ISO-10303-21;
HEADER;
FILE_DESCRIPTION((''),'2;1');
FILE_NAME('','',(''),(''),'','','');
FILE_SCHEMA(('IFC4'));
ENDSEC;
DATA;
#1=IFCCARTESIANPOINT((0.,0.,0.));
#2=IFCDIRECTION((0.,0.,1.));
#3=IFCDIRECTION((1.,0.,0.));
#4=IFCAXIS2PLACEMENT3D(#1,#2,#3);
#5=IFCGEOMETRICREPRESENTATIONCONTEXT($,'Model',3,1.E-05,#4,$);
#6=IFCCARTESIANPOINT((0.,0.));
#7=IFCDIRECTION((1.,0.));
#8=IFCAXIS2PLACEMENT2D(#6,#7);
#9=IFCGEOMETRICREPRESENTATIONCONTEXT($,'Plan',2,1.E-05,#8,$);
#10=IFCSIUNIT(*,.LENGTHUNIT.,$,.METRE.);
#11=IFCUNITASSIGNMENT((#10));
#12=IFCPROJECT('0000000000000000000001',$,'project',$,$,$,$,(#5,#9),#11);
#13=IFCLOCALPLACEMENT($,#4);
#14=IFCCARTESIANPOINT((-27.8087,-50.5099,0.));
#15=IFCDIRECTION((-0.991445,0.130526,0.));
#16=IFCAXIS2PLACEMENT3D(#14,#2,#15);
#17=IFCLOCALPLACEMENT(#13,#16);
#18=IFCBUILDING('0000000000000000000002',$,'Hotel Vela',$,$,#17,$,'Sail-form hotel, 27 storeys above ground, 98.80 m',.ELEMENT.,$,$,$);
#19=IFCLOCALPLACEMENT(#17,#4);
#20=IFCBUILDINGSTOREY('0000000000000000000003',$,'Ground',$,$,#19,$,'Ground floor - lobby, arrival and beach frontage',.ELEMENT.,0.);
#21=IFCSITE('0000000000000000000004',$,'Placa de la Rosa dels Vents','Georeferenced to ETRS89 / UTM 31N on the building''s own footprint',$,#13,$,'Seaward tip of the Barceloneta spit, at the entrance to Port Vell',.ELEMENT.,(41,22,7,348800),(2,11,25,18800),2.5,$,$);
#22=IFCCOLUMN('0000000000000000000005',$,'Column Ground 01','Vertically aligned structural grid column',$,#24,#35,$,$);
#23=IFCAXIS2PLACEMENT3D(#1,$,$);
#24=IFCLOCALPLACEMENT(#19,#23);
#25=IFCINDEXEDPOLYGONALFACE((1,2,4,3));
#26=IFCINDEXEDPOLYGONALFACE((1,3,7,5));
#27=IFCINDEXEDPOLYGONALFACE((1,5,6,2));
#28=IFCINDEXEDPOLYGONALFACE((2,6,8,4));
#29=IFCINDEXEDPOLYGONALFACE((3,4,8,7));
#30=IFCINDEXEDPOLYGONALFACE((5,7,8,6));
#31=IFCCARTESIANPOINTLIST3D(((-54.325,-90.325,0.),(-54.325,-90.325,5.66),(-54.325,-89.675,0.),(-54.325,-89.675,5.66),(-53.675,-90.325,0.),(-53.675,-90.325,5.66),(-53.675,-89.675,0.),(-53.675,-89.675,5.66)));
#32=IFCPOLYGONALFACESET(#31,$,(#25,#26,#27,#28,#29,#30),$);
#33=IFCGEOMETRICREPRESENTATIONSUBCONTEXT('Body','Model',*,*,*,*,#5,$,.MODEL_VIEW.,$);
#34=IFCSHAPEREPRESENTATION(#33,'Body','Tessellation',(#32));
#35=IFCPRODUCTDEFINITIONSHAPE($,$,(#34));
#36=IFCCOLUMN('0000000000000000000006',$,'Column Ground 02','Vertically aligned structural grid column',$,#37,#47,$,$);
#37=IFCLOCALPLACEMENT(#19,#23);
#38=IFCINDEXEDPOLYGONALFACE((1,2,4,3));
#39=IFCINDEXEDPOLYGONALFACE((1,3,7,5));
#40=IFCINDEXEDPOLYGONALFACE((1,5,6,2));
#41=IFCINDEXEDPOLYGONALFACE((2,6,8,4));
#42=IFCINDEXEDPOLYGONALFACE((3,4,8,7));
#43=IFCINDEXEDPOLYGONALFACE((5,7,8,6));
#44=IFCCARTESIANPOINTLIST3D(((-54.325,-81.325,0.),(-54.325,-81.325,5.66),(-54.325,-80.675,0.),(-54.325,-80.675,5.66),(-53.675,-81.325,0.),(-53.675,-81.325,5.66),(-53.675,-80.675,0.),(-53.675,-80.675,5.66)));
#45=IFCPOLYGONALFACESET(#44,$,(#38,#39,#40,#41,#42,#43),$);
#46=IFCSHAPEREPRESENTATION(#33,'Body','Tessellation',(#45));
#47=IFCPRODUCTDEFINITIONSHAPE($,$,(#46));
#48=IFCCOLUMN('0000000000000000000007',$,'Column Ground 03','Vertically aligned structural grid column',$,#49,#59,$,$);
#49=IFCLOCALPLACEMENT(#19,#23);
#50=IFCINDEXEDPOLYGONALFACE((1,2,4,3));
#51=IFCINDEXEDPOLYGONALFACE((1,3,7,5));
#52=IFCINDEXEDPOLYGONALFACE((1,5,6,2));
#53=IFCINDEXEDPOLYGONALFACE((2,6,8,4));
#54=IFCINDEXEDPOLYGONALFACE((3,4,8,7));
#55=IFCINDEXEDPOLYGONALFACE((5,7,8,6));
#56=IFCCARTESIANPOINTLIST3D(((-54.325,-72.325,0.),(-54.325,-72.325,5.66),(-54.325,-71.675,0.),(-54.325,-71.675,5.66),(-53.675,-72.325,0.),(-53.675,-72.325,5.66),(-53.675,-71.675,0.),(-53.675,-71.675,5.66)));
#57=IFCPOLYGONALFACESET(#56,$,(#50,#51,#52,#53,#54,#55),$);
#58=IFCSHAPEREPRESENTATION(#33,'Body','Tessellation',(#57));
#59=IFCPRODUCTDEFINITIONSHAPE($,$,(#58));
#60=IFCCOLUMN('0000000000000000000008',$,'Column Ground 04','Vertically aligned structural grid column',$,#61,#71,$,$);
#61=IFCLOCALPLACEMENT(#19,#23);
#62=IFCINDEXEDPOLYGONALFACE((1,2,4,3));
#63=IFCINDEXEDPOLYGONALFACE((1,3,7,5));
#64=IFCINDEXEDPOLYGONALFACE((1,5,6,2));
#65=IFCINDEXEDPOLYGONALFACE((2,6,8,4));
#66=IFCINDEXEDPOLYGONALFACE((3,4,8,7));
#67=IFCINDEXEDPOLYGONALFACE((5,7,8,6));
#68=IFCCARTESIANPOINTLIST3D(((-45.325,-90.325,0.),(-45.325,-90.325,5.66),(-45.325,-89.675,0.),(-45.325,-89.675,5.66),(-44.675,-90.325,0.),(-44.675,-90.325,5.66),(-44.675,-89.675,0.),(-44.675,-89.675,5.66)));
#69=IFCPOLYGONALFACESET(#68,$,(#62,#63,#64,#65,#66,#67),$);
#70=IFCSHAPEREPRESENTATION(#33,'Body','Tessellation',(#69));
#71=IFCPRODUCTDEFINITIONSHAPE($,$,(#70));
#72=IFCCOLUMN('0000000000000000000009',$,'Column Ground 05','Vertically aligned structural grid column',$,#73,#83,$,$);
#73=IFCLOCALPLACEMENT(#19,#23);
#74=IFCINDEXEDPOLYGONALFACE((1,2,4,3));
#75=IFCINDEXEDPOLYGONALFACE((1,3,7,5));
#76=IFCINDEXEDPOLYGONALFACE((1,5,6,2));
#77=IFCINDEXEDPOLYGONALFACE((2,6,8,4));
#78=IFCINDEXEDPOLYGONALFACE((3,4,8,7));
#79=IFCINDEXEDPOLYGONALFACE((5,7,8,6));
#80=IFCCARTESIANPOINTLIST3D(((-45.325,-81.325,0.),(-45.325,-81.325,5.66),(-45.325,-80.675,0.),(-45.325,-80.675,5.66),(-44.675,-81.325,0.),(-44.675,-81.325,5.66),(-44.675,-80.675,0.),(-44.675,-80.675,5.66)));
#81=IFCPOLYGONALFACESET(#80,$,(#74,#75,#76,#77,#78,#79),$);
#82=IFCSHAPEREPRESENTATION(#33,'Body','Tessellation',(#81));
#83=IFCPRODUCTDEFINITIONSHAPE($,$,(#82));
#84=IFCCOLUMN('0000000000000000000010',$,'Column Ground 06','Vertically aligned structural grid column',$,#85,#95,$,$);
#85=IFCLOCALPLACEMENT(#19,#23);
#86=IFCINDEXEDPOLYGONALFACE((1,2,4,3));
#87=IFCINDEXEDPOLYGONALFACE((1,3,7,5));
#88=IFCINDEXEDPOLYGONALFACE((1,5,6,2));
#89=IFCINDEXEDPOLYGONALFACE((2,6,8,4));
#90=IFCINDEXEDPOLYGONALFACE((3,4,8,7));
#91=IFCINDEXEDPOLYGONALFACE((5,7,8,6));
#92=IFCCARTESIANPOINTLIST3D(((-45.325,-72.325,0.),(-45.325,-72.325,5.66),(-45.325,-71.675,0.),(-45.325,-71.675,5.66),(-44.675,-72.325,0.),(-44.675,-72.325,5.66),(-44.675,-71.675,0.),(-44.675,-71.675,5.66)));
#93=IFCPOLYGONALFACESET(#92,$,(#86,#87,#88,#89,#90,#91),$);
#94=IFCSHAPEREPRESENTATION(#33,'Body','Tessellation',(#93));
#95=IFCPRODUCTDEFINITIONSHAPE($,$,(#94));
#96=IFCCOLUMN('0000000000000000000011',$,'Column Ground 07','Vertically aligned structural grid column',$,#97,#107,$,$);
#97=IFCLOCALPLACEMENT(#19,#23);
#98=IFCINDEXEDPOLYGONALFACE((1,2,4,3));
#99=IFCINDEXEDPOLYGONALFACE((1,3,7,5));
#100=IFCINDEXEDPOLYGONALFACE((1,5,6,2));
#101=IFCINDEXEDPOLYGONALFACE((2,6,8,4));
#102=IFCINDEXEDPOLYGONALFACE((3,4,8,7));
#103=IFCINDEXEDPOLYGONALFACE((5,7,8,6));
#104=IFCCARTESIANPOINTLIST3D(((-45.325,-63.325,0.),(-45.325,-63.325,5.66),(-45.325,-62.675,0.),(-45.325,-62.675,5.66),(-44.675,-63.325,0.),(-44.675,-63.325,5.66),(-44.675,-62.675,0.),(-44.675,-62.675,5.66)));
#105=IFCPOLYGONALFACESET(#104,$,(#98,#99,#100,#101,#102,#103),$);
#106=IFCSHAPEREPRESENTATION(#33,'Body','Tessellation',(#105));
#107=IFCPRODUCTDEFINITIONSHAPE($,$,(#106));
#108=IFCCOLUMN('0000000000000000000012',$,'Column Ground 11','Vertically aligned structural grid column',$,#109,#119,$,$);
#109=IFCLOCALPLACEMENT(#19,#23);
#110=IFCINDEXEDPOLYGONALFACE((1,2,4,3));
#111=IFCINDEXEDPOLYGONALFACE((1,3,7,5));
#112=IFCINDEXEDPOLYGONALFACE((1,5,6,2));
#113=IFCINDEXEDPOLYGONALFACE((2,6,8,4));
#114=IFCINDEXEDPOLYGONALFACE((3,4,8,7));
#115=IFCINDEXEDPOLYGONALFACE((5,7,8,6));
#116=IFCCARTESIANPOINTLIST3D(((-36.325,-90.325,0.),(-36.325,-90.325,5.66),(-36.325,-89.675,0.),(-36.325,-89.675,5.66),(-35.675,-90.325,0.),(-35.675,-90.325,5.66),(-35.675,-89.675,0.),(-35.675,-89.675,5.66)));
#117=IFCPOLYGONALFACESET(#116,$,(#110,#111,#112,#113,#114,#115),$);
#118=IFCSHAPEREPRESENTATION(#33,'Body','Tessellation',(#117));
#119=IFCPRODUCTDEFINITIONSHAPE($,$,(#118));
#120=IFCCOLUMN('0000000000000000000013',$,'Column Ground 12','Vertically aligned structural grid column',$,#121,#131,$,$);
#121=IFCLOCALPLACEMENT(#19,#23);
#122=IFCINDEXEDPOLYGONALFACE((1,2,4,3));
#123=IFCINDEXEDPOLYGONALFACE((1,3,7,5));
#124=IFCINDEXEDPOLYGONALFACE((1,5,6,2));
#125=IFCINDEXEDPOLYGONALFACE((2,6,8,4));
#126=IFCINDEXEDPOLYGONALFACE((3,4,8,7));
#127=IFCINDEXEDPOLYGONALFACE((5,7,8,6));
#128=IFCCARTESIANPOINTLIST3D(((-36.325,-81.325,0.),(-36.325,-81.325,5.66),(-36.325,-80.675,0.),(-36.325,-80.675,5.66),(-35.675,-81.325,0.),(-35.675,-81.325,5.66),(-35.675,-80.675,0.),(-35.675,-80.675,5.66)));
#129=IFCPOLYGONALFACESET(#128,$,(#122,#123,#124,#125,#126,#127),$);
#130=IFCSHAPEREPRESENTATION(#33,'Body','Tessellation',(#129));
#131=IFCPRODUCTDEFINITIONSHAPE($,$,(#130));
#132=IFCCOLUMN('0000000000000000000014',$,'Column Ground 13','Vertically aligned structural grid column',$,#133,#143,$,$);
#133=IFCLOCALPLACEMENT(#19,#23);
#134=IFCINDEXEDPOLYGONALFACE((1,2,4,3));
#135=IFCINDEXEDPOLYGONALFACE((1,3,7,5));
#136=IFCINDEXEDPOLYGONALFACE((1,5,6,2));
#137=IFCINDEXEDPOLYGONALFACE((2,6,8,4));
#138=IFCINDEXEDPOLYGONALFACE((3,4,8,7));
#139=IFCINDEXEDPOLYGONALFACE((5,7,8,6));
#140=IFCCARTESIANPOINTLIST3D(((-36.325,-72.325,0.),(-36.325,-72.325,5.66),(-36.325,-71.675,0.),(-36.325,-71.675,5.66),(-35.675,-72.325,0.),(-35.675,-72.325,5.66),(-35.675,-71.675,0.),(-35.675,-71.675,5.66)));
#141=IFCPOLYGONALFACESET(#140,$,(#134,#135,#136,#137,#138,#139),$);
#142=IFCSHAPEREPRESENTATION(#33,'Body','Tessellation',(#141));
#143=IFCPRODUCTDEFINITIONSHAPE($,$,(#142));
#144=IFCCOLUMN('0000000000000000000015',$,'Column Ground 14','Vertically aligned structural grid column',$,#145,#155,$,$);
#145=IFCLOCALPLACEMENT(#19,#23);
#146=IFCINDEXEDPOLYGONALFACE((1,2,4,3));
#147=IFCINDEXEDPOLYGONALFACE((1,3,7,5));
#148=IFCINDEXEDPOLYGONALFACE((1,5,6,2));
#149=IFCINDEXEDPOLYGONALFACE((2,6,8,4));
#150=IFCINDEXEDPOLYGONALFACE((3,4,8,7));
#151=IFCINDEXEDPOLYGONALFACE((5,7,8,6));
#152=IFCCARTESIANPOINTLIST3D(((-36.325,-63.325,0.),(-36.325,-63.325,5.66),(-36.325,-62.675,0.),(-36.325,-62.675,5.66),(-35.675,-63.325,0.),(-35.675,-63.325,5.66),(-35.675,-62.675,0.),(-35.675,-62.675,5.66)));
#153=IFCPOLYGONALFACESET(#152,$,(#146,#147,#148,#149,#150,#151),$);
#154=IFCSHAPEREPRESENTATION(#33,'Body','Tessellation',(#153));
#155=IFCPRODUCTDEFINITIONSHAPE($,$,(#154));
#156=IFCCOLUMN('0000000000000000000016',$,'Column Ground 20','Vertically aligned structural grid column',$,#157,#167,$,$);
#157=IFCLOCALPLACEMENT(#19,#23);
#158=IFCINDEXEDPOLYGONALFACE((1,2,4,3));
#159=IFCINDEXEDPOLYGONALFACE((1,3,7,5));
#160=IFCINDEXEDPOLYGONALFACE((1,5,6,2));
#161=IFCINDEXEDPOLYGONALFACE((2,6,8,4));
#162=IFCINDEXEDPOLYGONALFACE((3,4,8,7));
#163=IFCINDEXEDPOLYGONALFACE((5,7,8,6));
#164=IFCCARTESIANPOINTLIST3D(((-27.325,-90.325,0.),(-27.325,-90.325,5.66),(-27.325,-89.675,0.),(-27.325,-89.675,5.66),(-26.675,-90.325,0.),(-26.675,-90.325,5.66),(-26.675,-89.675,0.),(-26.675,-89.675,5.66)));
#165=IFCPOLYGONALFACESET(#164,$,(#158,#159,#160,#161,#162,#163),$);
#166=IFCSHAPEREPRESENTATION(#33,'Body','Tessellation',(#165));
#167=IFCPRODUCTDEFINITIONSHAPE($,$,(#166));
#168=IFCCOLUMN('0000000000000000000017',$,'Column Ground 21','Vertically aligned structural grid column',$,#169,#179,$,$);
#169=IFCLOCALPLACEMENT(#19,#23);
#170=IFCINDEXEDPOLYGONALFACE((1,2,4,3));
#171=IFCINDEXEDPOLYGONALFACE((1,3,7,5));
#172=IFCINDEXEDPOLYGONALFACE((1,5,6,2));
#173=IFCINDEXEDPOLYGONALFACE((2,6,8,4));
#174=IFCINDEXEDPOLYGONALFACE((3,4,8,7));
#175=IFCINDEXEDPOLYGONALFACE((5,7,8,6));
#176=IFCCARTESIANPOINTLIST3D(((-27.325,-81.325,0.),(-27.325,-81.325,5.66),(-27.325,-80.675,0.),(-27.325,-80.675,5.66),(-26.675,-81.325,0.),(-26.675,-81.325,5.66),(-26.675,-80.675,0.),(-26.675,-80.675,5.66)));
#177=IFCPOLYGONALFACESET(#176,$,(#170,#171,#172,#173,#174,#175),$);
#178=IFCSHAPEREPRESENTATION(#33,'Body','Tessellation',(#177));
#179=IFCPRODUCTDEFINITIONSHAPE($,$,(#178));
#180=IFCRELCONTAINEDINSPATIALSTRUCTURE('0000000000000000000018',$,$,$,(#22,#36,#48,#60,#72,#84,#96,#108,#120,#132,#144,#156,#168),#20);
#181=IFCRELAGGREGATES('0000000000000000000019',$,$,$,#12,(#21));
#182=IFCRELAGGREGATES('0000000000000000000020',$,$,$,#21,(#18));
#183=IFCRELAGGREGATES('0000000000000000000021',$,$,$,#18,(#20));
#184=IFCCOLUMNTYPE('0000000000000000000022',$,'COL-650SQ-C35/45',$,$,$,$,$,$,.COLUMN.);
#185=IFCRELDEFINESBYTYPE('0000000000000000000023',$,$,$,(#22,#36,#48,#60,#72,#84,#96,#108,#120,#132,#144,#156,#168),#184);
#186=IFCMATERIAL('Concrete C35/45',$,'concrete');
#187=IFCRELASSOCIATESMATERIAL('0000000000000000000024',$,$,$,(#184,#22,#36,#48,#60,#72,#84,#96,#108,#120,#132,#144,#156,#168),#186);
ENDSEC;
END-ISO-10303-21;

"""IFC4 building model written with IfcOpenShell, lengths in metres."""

from ifc_helpers import new_model, si_unit, frame, origin_with_axes, origin_2d_with_axis, place, context, subcontext, project, spatial, line, indexed_curve, rectangle, outline, extrude, material, material_profile, profile_set, profile_usage, type_object, element, save


model = new_model("IFC4")

# Units and contexts
model_context = context("Model", 3, precision=1e-05, world=origin_with_axes())
plan_context = context("Plan", 2, precision=1e-05, world=origin_2d_with_axis())
body_context = subcontext(model_context, "Body", "Model", "MODEL_VIEW")
ifc_project = project(units=[si_unit("LENGTHUNIT", "METRE")], contexts=[model_context, plan_context])

# Site, building, storey
site_placement = place(None, origin_with_axes())
site = spatial("IfcSite", under=ifc_project, at=site_placement, Name="Placa de la Rosa dels Vents", Description="Georeferenced to ETRS89 / UTM 31N on the building's own footprint", LongName="Seaward tip of the Barceloneta spit, at the entrance to Port Vell", CompositionType="ELEMENT", RefLatitude=(41, 22, 7, 348800), RefLongitude=(2, 11, 25, 18800), RefElevation=2.5)
building_placement = place(site_placement, frame((-27.8087, -50.5099, 0.0), z_axis=(0.0, 0.0, 1.0), x_axis=(-0.991445, 0.130526, 0.0)))
building = spatial("IfcBuilding", under=site, at=building_placement, Name="Hotel Vela", LongName="Sail-form hotel, 27 storeys above ground, 98.80 m", CompositionType="ELEMENT")
storey_placement = place(building_placement, origin_with_axes())
storey = spatial("IfcBuildingStorey", under=building, at=storey_placement, Name="Ground", LongName="Ground floor - lobby, arrival and beach frontage", CompositionType="ELEMENT", Elevation=0.0)

# Columns
ifc_material = material(Name="Concrete C35/45", Category="concrete")
ifc_material_profile = material_profile(ifc_material, rectangle(XDim=0.65, YDim=0.65))
ifc_profile_set = profile_set([ifc_material_profile], Name="COL-650SQ-C35/45")
ifc_profile_usage_1 = profile_usage(ifc_profile_set)
column_type = type_object("IfcColumnType", Name="COL-650SQ-C35/45", PredefinedType="COLUMN", material=ifc_profile_set)
column_1_placement = place(storey_placement, frame((-54.325, -90.325, 0.0), z_axis=(0.0, 0.0, 1.0), x_axis=(1.0, 0.0, 0.0)))
element("IfcColumn", 1, at=column_1_placement, inside=storey, type_object=column_type, material=ifc_profile_usage_1, Name="Column Ground 01", Description="Vertically aligned structural grid column", context=body_context, shape_type="SweptSolid", body=[
    extrude(outline(indexed_curve([(0.0, 0.0), (0.65, 0.0), (0.65, 0.65), (0.0, 0.65)], segments=[line(1, 2, 3, 4, 1)])), origin_with_axes(), (0.0, 0.0, 1.0), 5.66),
])
ifc_profile_usage_2 = profile_usage(ifc_profile_set)
column_2_placement = place(storey_placement, frame((-54.325, -81.325, 0.0), z_axis=(0.0, 0.0, 1.0), x_axis=(1.0, 0.0, 0.0)))
element("IfcColumn", 2, at=column_2_placement, inside=storey, type_object=column_type, material=ifc_profile_usage_2, Name="Column Ground 02", Description="Vertically aligned structural grid column", context=body_context, shape_type="SweptSolid", body=[
    extrude(outline(indexed_curve([(0.0, 0.0), (0.65, 0.0), (0.65, 0.65), (0.0, 0.65)], segments=[line(1, 2, 3, 4, 1)])), origin_with_axes(), (0.0, 0.0, 1.0), 5.66),
])
ifc_profile_usage_3 = profile_usage(ifc_profile_set)
column_3_placement = place(storey_placement, frame((-54.325, -72.325, 0.0), z_axis=(0.0, 0.0, 1.0), x_axis=(1.0, 0.0, 0.0)))
element("IfcColumn", 3, at=column_3_placement, inside=storey, type_object=column_type, material=ifc_profile_usage_3, Name="Column Ground 03", Description="Vertically aligned structural grid column", context=body_context, shape_type="SweptSolid", body=[
    extrude(outline(indexed_curve([(0.0, 0.0), (0.65, 0.0), (0.65, 0.65), (0.0, 0.65)], segments=[line(1, 2, 3, 4, 1)])), origin_with_axes(), (0.0, 0.0, 1.0), 5.66),
])
ifc_profile_usage_4 = profile_usage(ifc_profile_set)
column_4_placement = place(storey_placement, frame((-45.325, -90.325, 0.0), z_axis=(0.0, 0.0, 1.0), x_axis=(1.0, 0.0, 0.0)))
element("IfcColumn", 4, at=column_4_placement, inside=storey, type_object=column_type, material=ifc_profile_usage_4, Name="Column Ground 04", Description="Vertically aligned structural grid column", context=body_context, shape_type="SweptSolid", body=[
    extrude(outline(indexed_curve([(0.0, 0.0), (0.65, 0.0), (0.65, 0.65), (0.0, 0.65)], segments=[line(1, 2, 3, 4, 1)])), origin_with_axes(), (0.0, 0.0, 1.0), 5.66),
])
ifc_profile_usage_5 = profile_usage(ifc_profile_set)
column_5_placement = place(storey_placement, frame((-45.325, -81.325, 0.0), z_axis=(0.0, 0.0, 1.0), x_axis=(1.0, 0.0, 0.0)))
element("IfcColumn", 5, at=column_5_placement, inside=storey, type_object=column_type, material=ifc_profile_usage_5, Name="Column Ground 05", Description="Vertically aligned structural grid column", context=body_context, shape_type="SweptSolid", body=[
    extrude(outline(indexed_curve([(0.0, 0.0), (0.65, 0.0), (0.65, 0.65), (0.0, 0.65)], segments=[line(1, 2, 3, 4, 1)])), origin_with_axes(), (0.0, 0.0, 1.0), 5.66),
])
ifc_profile_usage_6 = profile_usage(ifc_profile_set)
column_6_placement = place(storey_placement, frame((-45.325, -72.325, 0.0), z_axis=(0.0, 0.0, 1.0), x_axis=(1.0, 0.0, 0.0)))
element("IfcColumn", 6, at=column_6_placement, inside=storey, type_object=column_type, material=ifc_profile_usage_6, Name="Column Ground 06", Description="Vertically aligned structural grid column", context=body_context, shape_type="SweptSolid", body=[
    extrude(outline(indexed_curve([(0.0, 0.0), (0.65, 0.0), (0.65, 0.65), (0.0, 0.65)], segments=[line(1, 2, 3, 4, 1)])), origin_with_axes(), (0.0, 0.0, 1.0), 5.66),
])
ifc_profile_usage_7 = profile_usage(ifc_profile_set)
column_7_placement = place(storey_placement, frame((-45.325, -63.325, 0.0), z_axis=(0.0, 0.0, 1.0), x_axis=(1.0, 0.0, 0.0)))
element("IfcColumn", 7, at=column_7_placement, inside=storey, type_object=column_type, material=ifc_profile_usage_7, Name="Column Ground 07", Description="Vertically aligned structural grid column", context=body_context, shape_type="SweptSolid", body=[
    extrude(outline(indexed_curve([(0.0, 0.0), (0.65, 0.0), (0.65, 0.65), (0.0, 0.65)], segments=[line(1, 2, 3, 4, 1)])), origin_with_axes(), (0.0, 0.0, 1.0), 5.66),
])
ifc_profile_usage_8 = profile_usage(ifc_profile_set)
column_8_placement = place(storey_placement, frame((-36.325, -90.325, 0.0), z_axis=(0.0, 0.0, 1.0), x_axis=(1.0, 0.0, 0.0)))
element("IfcColumn", 8, at=column_8_placement, inside=storey, type_object=column_type, material=ifc_profile_usage_8, Name="Column Ground 11", Description="Vertically aligned structural grid column", context=body_context, shape_type="SweptSolid", body=[
    extrude(outline(indexed_curve([(0.0, 0.0), (0.65, 0.0), (0.65, 0.65), (0.0, 0.65)], segments=[line(1, 2, 3, 4, 1)])), origin_with_axes(), (0.0, 0.0, 1.0), 5.66),
])
ifc_profile_usage_9 = profile_usage(ifc_profile_set)
column_9_placement = place(storey_placement, frame((-36.325, -81.325, 0.0), z_axis=(0.0, 0.0, 1.0), x_axis=(1.0, 0.0, 0.0)))
element("IfcColumn", 9, at=column_9_placement, inside=storey, type_object=column_type, material=ifc_profile_usage_9, Name="Column Ground 12", Description="Vertically aligned structural grid column", context=body_context, shape_type="SweptSolid", body=[
    extrude(outline(indexed_curve([(0.0, 0.0), (0.65, 0.0), (0.65, 0.65), (0.0, 0.65)], segments=[line(1, 2, 3, 4, 1)])), origin_with_axes(), (0.0, 0.0, 1.0), 5.66),
])
ifc_profile_usage_10 = profile_usage(ifc_profile_set)
column_10_placement = place(storey_placement, frame((-36.325, -72.325, 0.0), z_axis=(0.0, 0.0, 1.0), x_axis=(1.0, 0.0, 0.0)))
element("IfcColumn", 10, at=column_10_placement, inside=storey, type_object=column_type, material=ifc_profile_usage_10, Name="Column Ground 13", Description="Vertically aligned structural grid column", context=body_context, shape_type="SweptSolid", body=[
    extrude(outline(indexed_curve([(0.0, 0.0), (0.65, 0.0), (0.65, 0.65), (0.0, 0.65)], segments=[line(1, 2, 3, 4, 1)])), origin_with_axes(), (0.0, 0.0, 1.0), 5.66),
])
ifc_profile_usage_11 = profile_usage(ifc_profile_set)
column_11_placement = place(storey_placement, frame((-36.325, -63.325, 0.0), z_axis=(0.0, 0.0, 1.0), x_axis=(1.0, 0.0, 0.0)))
element("IfcColumn", 11, at=column_11_placement, inside=storey, type_object=column_type, material=ifc_profile_usage_11, Name="Column Ground 14", Description="Vertically aligned structural grid column", context=body_context, shape_type="SweptSolid", body=[
    extrude(outline(indexed_curve([(0.0, 0.0), (0.65, 0.0), (0.65, 0.65), (0.0, 0.65)], segments=[line(1, 2, 3, 4, 1)])), origin_with_axes(), (0.0, 0.0, 1.0), 5.66),
])
ifc_profile_usage_12 = profile_usage(ifc_profile_set)
column_12_placement = place(storey_placement, frame((-27.325, -90.325, 0.0), z_axis=(0.0, 0.0, 1.0), x_axis=(1.0, 0.0, 0.0)))
element("IfcColumn", 12, at=column_12_placement, inside=storey, type_object=column_type, material=ifc_profile_usage_12, Name="Column Ground 20", Description="Vertically aligned structural grid column", context=body_context, shape_type="SweptSolid", body=[
    extrude(outline(indexed_curve([(0.0, 0.0), (0.65, 0.0), (0.65, 0.65), (0.0, 0.65)], segments=[line(1, 2, 3, 4, 1)])), origin_with_axes(), (0.0, 0.0, 1.0), 5.66),
])
ifc_profile_usage_13 = profile_usage(ifc_profile_set)
column_13_placement = place(storey_placement, frame((-27.325, -81.325, 0.0), z_axis=(0.0, 0.0, 1.0), x_axis=(1.0, 0.0, 0.0)))
element("IfcColumn", 13, at=column_13_placement, inside=storey, type_object=column_type, material=ifc_profile_usage_13, Name="Column Ground 21", Description="Vertically aligned structural grid column", context=body_context, shape_type="SweptSolid", body=[
    extrude(outline(indexed_curve([(0.0, 0.0), (0.65, 0.0), (0.65, 0.65), (0.0, 0.65)], segments=[line(1, 2, 3, 4, 1)])), origin_with_axes(), (0.0, 0.0, 1.0), 5.66),
])

save(model, "model.ifc")
